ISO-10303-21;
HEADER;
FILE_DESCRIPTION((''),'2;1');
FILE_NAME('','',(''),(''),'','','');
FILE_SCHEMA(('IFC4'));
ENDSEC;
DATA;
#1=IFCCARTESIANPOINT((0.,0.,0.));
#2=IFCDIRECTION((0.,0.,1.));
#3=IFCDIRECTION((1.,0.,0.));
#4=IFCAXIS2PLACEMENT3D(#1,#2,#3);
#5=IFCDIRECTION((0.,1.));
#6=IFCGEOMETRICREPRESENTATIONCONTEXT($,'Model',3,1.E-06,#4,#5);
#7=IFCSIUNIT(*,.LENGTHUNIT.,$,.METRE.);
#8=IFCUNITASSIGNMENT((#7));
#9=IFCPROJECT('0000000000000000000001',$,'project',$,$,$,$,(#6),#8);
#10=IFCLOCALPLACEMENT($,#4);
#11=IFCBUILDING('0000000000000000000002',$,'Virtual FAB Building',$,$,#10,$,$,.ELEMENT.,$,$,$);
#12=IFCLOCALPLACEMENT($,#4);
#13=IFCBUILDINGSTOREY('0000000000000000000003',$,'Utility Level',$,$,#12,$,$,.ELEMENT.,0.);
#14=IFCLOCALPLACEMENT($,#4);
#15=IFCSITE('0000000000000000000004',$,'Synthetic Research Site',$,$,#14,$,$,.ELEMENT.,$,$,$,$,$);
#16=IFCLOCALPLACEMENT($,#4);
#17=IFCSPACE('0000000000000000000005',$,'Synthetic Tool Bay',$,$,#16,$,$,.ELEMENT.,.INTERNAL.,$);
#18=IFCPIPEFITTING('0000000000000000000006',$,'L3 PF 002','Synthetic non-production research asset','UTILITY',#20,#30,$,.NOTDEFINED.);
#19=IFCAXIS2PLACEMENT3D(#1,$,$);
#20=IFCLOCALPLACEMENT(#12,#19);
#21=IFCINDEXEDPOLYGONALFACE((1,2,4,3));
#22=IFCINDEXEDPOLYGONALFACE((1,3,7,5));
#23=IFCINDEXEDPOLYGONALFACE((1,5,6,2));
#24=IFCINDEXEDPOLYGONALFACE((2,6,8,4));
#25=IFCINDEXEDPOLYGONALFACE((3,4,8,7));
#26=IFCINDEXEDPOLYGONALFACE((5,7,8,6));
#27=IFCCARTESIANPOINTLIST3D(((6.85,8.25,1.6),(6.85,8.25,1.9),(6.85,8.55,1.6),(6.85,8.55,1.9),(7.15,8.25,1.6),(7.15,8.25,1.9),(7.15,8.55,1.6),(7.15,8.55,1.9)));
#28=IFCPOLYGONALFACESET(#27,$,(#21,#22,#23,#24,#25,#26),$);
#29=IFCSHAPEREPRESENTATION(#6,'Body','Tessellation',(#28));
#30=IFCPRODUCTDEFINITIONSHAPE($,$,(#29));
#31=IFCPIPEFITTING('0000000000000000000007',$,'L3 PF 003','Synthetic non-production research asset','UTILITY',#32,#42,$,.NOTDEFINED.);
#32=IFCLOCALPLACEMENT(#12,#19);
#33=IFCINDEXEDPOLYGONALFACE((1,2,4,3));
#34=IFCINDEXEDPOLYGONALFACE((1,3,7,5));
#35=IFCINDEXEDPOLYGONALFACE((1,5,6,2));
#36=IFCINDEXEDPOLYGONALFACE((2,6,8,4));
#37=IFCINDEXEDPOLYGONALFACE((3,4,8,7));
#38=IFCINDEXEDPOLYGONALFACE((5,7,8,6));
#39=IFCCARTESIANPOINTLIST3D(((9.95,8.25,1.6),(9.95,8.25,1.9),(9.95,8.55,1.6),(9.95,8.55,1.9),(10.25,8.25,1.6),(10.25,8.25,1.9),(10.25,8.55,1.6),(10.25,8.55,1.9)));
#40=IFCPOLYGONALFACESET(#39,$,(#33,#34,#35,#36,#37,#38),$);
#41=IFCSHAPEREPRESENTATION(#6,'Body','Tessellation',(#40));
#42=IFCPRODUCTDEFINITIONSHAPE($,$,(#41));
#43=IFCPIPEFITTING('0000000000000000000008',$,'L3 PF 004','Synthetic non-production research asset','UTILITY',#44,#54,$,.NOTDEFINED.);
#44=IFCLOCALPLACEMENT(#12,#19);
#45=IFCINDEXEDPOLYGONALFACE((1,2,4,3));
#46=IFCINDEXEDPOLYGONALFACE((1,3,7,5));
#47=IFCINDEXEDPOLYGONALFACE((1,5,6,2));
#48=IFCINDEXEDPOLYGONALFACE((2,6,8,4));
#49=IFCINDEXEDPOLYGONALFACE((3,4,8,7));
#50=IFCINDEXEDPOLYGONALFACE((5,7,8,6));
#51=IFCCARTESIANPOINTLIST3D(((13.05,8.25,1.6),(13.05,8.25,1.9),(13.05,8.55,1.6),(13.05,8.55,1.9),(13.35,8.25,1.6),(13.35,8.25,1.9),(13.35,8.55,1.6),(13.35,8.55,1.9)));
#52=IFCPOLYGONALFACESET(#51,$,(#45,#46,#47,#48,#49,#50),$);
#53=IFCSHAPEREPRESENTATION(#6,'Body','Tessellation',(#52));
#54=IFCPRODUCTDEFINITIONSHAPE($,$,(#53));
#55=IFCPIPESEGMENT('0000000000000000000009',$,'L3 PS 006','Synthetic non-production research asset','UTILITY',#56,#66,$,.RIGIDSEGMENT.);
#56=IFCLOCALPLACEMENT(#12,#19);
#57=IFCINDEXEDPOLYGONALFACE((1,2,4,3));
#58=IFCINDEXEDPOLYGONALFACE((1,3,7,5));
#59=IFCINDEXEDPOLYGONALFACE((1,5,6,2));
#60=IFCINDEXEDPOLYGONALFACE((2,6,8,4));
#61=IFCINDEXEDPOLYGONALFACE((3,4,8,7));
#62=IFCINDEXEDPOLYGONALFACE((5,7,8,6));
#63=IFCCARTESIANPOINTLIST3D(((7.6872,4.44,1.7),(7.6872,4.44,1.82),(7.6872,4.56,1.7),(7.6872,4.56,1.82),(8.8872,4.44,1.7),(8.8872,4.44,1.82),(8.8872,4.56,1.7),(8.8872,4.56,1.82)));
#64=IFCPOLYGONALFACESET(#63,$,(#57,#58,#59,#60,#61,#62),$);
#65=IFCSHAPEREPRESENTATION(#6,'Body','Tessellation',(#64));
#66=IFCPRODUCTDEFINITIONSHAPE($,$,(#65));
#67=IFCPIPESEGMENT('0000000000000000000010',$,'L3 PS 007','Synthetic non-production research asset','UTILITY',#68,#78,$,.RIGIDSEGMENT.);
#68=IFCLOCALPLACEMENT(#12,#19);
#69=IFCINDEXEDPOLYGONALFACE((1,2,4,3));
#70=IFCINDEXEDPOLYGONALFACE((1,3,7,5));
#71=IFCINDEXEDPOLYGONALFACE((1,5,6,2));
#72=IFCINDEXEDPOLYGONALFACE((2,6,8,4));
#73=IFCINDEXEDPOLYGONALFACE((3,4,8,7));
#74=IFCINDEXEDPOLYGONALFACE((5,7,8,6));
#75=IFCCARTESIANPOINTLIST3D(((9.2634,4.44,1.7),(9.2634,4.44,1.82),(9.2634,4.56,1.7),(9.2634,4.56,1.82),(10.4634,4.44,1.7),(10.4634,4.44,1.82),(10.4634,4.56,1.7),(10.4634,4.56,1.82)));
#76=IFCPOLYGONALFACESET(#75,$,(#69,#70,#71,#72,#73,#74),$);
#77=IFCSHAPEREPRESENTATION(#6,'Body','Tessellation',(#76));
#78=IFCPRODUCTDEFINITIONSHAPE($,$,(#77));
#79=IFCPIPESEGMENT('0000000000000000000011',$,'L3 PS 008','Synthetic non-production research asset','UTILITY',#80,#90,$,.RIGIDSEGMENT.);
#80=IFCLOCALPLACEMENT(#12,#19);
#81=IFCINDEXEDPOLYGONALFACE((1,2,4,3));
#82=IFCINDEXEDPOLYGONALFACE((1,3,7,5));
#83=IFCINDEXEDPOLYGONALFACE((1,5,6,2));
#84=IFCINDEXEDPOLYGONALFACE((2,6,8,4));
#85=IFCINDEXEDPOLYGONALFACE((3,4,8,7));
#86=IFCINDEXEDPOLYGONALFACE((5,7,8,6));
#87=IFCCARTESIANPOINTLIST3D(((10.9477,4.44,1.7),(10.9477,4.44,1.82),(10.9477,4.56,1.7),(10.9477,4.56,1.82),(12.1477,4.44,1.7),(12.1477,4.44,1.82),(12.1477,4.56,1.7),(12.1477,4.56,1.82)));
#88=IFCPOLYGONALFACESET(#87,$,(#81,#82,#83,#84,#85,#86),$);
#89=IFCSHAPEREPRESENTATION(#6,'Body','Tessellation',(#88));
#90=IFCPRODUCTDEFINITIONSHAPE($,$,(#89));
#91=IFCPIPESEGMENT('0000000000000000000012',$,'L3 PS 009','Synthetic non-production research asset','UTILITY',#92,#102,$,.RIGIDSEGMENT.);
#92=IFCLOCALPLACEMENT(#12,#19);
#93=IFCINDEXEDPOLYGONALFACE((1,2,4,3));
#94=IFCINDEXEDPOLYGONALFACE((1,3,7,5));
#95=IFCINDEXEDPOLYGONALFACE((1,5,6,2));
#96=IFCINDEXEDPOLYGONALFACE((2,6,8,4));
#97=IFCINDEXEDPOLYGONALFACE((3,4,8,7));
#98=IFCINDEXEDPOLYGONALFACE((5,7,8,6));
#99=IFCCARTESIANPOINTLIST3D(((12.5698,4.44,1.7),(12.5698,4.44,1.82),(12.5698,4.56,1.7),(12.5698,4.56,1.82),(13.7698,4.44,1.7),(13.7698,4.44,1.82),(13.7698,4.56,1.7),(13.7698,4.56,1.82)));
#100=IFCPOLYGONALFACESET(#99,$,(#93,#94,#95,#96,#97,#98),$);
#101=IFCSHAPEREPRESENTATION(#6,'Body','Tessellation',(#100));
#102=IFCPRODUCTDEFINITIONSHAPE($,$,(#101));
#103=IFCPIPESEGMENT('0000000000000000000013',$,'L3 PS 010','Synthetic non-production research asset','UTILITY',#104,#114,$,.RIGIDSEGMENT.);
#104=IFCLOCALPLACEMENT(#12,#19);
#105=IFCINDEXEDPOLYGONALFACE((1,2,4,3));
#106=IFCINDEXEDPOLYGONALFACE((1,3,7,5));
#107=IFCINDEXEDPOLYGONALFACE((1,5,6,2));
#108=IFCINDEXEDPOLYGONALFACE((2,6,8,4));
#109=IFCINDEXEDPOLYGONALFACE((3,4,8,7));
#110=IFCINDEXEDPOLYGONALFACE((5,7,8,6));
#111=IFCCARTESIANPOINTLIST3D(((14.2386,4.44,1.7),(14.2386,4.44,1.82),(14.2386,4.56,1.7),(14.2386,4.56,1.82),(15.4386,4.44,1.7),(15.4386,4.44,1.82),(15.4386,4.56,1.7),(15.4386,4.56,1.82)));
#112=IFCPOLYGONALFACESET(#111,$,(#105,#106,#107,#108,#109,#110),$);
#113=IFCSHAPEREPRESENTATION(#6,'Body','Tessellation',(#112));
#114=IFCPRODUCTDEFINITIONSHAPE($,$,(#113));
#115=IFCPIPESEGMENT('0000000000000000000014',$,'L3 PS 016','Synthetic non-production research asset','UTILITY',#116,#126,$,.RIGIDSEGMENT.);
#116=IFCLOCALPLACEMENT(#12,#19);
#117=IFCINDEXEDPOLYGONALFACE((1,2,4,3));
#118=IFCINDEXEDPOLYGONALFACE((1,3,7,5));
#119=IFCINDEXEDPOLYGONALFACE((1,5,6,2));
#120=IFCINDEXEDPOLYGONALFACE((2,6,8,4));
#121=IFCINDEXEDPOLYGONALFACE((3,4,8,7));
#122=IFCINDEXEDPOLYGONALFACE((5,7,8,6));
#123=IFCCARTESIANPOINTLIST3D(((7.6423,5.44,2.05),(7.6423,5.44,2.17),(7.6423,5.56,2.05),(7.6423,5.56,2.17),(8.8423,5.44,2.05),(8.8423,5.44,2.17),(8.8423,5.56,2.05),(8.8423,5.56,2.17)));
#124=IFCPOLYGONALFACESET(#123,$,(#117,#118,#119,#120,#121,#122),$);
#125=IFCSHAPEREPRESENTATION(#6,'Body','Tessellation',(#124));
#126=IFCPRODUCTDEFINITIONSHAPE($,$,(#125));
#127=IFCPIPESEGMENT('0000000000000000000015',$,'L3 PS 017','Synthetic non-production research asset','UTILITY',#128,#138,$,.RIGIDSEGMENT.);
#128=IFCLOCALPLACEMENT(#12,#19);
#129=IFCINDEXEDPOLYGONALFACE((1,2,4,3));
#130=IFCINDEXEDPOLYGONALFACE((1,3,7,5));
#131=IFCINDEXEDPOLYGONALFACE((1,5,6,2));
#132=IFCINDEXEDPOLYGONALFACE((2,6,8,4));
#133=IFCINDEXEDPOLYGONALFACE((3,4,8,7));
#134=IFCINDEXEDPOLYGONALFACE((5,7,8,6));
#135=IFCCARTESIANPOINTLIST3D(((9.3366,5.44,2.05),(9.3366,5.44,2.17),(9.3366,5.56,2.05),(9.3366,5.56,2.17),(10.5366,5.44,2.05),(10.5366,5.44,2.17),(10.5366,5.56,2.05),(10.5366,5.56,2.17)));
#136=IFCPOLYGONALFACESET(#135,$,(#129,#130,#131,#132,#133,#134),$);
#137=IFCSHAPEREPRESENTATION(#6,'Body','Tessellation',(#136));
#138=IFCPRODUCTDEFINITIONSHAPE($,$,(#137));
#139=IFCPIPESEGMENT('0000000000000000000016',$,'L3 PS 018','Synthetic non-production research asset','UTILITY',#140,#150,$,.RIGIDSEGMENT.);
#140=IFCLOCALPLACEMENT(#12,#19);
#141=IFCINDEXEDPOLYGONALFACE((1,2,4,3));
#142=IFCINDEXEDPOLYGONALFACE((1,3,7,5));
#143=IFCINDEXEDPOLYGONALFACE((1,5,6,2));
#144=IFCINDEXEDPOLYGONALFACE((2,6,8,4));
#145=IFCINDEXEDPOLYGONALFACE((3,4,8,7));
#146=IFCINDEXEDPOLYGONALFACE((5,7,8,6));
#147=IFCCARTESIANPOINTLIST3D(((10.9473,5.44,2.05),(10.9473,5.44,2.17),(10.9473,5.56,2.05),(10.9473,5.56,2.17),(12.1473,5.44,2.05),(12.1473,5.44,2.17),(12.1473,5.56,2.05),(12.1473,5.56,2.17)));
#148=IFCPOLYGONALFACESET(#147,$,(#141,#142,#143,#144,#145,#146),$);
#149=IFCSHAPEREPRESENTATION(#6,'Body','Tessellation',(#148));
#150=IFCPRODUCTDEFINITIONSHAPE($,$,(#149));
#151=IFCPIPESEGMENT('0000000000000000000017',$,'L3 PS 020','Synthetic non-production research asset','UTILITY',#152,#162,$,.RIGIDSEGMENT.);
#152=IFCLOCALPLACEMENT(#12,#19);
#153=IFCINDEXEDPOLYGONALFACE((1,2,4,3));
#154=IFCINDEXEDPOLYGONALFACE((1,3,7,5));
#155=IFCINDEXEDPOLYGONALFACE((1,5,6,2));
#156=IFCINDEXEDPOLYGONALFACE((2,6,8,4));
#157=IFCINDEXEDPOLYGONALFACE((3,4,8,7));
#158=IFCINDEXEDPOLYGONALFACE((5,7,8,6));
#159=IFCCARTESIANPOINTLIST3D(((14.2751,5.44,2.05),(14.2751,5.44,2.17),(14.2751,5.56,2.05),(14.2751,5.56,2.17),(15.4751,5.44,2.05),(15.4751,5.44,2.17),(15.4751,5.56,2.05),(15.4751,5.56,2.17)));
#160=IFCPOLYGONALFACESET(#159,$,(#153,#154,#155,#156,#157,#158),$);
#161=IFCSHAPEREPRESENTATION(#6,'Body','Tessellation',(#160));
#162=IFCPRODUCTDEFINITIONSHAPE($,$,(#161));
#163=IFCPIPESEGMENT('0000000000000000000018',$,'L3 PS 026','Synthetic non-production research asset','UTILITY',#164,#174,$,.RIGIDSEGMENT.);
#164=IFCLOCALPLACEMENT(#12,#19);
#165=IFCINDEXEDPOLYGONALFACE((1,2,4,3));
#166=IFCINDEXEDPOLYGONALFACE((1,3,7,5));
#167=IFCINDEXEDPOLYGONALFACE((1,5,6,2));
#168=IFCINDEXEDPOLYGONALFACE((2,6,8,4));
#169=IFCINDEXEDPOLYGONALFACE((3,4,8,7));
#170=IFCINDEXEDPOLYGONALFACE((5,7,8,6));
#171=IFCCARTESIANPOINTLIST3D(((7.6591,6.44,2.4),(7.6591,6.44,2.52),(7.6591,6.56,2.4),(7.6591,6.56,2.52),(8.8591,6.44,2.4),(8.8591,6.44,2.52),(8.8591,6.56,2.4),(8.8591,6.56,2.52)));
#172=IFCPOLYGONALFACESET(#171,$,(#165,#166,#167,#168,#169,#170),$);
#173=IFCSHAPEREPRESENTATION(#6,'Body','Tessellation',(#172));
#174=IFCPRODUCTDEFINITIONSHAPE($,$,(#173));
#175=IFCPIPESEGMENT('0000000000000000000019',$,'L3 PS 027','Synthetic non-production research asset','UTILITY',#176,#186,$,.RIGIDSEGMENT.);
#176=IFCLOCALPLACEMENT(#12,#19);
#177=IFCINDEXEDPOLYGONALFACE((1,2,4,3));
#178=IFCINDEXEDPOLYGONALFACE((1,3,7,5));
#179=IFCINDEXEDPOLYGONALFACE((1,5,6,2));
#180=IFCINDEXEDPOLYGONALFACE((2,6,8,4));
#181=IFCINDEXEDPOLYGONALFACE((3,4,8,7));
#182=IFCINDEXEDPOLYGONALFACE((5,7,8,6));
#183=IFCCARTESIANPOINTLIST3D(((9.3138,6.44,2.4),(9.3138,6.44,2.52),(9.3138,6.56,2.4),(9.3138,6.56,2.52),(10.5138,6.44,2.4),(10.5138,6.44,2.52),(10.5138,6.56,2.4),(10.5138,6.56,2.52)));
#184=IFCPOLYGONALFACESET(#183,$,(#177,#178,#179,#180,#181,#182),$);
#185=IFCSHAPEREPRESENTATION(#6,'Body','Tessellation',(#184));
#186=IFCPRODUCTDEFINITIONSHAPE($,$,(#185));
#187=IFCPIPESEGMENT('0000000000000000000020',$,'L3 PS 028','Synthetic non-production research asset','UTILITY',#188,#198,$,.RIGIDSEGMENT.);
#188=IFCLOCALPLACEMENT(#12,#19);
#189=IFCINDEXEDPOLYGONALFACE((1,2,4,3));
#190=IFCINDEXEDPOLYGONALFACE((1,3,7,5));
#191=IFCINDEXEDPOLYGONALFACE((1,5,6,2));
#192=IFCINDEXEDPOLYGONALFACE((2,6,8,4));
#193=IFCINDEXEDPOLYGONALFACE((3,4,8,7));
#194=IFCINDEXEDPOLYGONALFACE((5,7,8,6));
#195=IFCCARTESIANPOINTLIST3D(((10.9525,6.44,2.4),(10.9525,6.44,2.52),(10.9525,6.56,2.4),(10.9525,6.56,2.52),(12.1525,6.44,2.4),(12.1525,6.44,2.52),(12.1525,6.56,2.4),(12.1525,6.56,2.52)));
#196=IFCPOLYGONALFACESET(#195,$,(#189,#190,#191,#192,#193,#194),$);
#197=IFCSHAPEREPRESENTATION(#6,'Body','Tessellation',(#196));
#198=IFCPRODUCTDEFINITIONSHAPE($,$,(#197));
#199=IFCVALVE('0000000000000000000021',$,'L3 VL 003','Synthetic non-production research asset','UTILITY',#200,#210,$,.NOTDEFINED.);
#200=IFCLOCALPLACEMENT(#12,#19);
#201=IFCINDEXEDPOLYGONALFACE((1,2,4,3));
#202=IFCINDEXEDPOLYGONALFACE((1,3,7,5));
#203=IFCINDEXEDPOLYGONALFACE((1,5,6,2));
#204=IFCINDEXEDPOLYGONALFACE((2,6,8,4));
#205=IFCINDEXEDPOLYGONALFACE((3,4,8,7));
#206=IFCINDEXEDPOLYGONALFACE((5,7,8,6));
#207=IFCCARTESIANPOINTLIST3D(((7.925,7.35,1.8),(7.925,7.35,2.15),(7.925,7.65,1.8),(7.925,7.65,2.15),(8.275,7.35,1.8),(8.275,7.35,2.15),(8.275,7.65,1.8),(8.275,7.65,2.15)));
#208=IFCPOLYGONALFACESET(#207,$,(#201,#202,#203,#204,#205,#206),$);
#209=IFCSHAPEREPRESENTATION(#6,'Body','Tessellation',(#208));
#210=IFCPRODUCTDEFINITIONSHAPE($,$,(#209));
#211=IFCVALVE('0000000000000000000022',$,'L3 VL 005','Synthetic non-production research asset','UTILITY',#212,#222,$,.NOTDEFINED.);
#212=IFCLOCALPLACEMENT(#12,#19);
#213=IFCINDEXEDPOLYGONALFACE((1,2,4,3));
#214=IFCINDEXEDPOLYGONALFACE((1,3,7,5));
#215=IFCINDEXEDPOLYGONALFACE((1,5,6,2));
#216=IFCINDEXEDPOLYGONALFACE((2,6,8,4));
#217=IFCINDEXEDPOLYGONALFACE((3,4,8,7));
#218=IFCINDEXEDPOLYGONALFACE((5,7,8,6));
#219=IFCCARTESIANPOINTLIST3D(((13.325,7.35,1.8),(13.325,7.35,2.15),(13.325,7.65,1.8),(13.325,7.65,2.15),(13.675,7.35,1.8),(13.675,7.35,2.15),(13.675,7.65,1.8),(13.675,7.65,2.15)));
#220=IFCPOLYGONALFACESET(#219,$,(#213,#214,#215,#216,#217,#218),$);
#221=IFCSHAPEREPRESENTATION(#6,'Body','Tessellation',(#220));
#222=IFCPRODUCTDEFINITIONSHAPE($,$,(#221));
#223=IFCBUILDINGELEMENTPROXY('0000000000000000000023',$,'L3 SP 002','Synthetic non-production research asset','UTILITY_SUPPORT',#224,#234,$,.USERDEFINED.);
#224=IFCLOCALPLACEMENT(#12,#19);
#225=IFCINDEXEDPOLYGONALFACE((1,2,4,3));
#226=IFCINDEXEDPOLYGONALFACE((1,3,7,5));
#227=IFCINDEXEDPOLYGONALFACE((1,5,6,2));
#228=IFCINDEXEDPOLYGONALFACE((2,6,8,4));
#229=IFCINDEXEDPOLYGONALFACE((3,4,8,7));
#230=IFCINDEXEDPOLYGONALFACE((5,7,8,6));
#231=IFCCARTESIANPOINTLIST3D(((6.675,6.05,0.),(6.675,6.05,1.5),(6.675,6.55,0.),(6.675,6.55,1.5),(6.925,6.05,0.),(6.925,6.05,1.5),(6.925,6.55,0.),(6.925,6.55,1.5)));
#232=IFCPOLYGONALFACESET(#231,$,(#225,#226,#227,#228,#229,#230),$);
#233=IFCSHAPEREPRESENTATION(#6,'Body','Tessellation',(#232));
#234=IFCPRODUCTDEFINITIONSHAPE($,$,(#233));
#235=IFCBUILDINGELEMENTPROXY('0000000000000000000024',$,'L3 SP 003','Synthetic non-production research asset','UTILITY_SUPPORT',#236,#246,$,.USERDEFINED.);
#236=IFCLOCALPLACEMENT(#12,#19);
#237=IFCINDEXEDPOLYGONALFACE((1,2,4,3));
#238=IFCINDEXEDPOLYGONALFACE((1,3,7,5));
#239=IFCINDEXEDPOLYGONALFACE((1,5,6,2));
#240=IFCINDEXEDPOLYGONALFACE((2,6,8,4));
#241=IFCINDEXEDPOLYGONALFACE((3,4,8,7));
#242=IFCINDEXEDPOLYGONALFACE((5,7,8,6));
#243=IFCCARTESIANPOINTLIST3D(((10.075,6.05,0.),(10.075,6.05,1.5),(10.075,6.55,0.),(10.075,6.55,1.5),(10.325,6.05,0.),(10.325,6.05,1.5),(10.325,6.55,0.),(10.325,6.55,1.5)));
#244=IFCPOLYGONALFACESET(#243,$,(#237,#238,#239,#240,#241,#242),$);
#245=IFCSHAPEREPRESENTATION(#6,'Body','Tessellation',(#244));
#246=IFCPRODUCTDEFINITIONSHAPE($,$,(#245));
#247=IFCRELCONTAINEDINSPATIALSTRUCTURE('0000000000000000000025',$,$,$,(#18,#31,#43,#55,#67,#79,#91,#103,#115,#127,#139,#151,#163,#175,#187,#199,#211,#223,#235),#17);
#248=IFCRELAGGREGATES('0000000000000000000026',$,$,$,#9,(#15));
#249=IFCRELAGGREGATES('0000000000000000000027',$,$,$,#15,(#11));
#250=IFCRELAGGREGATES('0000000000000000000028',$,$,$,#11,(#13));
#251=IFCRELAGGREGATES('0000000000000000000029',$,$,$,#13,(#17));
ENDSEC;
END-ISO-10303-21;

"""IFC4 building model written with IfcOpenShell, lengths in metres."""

from ifc_helpers import new_model, si_unit, direction, frame, origin_with_axes, origin_2d_with_axis, place, context, project, spatial, rectangle, extrude, element, save


model = new_model("IFC4")

# Units and contexts
model_context = context("Model", 3, precision=1e-06, world=origin_with_axes(), true_north=direction((0.0, 1.0)))
ifc_project = project(units=[si_unit("LENGTHUNIT", "METRE")], contexts=[model_context])

# Site, building, storey, space
site_placement = place(None, origin_with_axes())
site = spatial("IfcSite", under=ifc_project, at=site_placement, Name="Synthetic Research Site", CompositionType="ELEMENT")
building_placement = place(None, origin_with_axes())
building = spatial("IfcBuilding", under=site, at=building_placement, Name="Virtual FAB Building", CompositionType="ELEMENT")
storey_placement = place(None, origin_with_axes())
storey = spatial("IfcBuildingStorey", under=building, at=storey_placement, Name="Utility Level", CompositionType="ELEMENT", Elevation=0.0)
space_placement = place(None, origin_with_axes())
space = spatial("IfcSpace", under=storey, at=space_placement, Name="Synthetic Tool Bay", CompositionType="ELEMENT", PredefinedType="INTERNAL")

# Pipe fittings
for number, where, z_axis, x_axis, name in (
    (1, (7.0, 8.4, 1.6), (0.0, 0.0, 1.0), (1.0, 0.0, 0.0), "L3 PF 002"),
    (2, (10.1, 8.4, 1.6), (0.0, 0.0, 1.0), (1.0, 0.0, 0.0), "L3 PF 003"),
    (3, (13.2, 8.4, 1.6), (0.0, 0.0, 1.0), (1.0, 0.0, 0.0), "L3 PF 004"),
):
    element("IfcPipeFitting", number, at=place(None, frame(where, z_axis=z_axis, x_axis=x_axis)), inside=space, Name=name, Description="Synthetic non-production research asset", ObjectType="UTILITY", PredefinedType="NOTDEFINED", context=model_context, shape_type="SweptSolid", body=[
        extrude(rectangle(XDim=0.3, YDim=0.3, at=origin_2d_with_axis()), origin_with_axes(), (0.0, 0.0, 1.0), 0.3),
    ])

# Pipe segments
for number, where, z_axis, x_axis, name in (
    (4, (8.2872, 4.5, 1.7), (0.0, 0.0, 1.0), (1.0, 0.0, 0.0), "L3 PS 006"),
    (5, (9.8634, 4.5, 1.7), (0.0, 0.0, 1.0), (1.0, 0.0, 0.0), "L3 PS 007"),
    (6, (11.5477, 4.5, 1.7), (0.0, 0.0, 1.0), (1.0, 0.0, 0.0), "L3 PS 008"),
    (7, (13.1698, 4.5, 1.7), (0.0, 0.0, 1.0), (1.0, 0.0, 0.0), "L3 PS 009"),
    (8, (14.8386, 4.5, 1.7), (0.0, 0.0, 1.0), (1.0, 0.0, 0.0), "L3 PS 010"),
    (9, (8.2423, 5.5, 2.05), (0.0, 0.0, 1.0), (1.0, 0.0, 0.0), "L3 PS 016"),
    (10, (9.9366, 5.5, 2.05), (0.0, 0.0, 1.0), (1.0, 0.0, 0.0), "L3 PS 017"),
    (11, (11.5473, 5.5, 2.05), (0.0, 0.0, 1.0), (1.0, 0.0, 0.0), "L3 PS 018"),
    (12, (14.8751, 5.5, 2.05), (0.0, 0.0, 1.0), (1.0, 0.0, 0.0), "L3 PS 020"),
    (13, (8.2591, 6.5, 2.4), (0.0, 0.0, 1.0), (1.0, 0.0, 0.0), "L3 PS 026"),
    (14, (9.9138, 6.5, 2.4), (0.0, 0.0, 1.0), (1.0, 0.0, 0.0), "L3 PS 027"),
    (15, (11.5525, 6.5, 2.4), (0.0, 0.0, 1.0), (1.0, 0.0, 0.0), "L3 PS 028"),
):
    element("IfcPipeSegment", number, at=place(None, frame(where, z_axis=z_axis, x_axis=x_axis)), inside=space, Name=name, Description="Synthetic non-production research asset", ObjectType="UTILITY", PredefinedType="RIGIDSEGMENT", context=model_context, shape_type="SweptSolid", body=[
        extrude(rectangle(XDim=1.2, YDim=0.12, at=origin_2d_with_axis()), origin_with_axes(), (0.0, 0.0, 1.0), 0.12),
    ])

# Valves
for number, where, z_axis, x_axis, name in (
    (16, (8.1, 7.5, 1.8), (0.0, 0.0, 1.0), (1.0, 0.0, 0.0), "L3 VL 003"),
    (17, (13.5, 7.5, 1.8), (0.0, 0.0, 1.0), (1.0, 0.0, 0.0), "L3 VL 005"),
):
    element("IfcValve", number, at=place(None, frame(where, z_axis=z_axis, x_axis=x_axis)), inside=space, Name=name, Description="Synthetic non-production research asset", ObjectType="UTILITY", PredefinedType="NOTDEFINED", context=model_context, shape_type="SweptSolid", body=[
        extrude(rectangle(XDim=0.35, YDim=0.3, at=origin_2d_with_axis()), origin_with_axes(), (0.0, 0.0, 1.0), 0.35),
    ])

# Building element proxies
for number, where, z_axis, x_axis, name in (
    (18, (6.8, 6.3, 0.0), (0.0, 0.0, 1.0), (1.0, 0.0, 0.0), "L3 SP 002"),
    (19, (10.2, 6.3, 0.0), (0.0, 0.0, 1.0), (1.0, 0.0, 0.0), "L3 SP 003"),
):
    element("IfcBuildingElementProxy", number, at=place(None, frame(where, z_axis=z_axis, x_axis=x_axis)), inside=space, Name=name, Description="Synthetic non-production research asset", ObjectType="UTILITY_SUPPORT", PredefinedType="USERDEFINED", context=model_context, shape_type="SweptSolid", body=[
        extrude(rectangle(XDim=0.25, YDim=0.5, at=origin_2d_with_axis()), origin_with_axes(), (0.0, 0.0, 1.0), 1.5),
    ])

save(model, "model.ifc")
